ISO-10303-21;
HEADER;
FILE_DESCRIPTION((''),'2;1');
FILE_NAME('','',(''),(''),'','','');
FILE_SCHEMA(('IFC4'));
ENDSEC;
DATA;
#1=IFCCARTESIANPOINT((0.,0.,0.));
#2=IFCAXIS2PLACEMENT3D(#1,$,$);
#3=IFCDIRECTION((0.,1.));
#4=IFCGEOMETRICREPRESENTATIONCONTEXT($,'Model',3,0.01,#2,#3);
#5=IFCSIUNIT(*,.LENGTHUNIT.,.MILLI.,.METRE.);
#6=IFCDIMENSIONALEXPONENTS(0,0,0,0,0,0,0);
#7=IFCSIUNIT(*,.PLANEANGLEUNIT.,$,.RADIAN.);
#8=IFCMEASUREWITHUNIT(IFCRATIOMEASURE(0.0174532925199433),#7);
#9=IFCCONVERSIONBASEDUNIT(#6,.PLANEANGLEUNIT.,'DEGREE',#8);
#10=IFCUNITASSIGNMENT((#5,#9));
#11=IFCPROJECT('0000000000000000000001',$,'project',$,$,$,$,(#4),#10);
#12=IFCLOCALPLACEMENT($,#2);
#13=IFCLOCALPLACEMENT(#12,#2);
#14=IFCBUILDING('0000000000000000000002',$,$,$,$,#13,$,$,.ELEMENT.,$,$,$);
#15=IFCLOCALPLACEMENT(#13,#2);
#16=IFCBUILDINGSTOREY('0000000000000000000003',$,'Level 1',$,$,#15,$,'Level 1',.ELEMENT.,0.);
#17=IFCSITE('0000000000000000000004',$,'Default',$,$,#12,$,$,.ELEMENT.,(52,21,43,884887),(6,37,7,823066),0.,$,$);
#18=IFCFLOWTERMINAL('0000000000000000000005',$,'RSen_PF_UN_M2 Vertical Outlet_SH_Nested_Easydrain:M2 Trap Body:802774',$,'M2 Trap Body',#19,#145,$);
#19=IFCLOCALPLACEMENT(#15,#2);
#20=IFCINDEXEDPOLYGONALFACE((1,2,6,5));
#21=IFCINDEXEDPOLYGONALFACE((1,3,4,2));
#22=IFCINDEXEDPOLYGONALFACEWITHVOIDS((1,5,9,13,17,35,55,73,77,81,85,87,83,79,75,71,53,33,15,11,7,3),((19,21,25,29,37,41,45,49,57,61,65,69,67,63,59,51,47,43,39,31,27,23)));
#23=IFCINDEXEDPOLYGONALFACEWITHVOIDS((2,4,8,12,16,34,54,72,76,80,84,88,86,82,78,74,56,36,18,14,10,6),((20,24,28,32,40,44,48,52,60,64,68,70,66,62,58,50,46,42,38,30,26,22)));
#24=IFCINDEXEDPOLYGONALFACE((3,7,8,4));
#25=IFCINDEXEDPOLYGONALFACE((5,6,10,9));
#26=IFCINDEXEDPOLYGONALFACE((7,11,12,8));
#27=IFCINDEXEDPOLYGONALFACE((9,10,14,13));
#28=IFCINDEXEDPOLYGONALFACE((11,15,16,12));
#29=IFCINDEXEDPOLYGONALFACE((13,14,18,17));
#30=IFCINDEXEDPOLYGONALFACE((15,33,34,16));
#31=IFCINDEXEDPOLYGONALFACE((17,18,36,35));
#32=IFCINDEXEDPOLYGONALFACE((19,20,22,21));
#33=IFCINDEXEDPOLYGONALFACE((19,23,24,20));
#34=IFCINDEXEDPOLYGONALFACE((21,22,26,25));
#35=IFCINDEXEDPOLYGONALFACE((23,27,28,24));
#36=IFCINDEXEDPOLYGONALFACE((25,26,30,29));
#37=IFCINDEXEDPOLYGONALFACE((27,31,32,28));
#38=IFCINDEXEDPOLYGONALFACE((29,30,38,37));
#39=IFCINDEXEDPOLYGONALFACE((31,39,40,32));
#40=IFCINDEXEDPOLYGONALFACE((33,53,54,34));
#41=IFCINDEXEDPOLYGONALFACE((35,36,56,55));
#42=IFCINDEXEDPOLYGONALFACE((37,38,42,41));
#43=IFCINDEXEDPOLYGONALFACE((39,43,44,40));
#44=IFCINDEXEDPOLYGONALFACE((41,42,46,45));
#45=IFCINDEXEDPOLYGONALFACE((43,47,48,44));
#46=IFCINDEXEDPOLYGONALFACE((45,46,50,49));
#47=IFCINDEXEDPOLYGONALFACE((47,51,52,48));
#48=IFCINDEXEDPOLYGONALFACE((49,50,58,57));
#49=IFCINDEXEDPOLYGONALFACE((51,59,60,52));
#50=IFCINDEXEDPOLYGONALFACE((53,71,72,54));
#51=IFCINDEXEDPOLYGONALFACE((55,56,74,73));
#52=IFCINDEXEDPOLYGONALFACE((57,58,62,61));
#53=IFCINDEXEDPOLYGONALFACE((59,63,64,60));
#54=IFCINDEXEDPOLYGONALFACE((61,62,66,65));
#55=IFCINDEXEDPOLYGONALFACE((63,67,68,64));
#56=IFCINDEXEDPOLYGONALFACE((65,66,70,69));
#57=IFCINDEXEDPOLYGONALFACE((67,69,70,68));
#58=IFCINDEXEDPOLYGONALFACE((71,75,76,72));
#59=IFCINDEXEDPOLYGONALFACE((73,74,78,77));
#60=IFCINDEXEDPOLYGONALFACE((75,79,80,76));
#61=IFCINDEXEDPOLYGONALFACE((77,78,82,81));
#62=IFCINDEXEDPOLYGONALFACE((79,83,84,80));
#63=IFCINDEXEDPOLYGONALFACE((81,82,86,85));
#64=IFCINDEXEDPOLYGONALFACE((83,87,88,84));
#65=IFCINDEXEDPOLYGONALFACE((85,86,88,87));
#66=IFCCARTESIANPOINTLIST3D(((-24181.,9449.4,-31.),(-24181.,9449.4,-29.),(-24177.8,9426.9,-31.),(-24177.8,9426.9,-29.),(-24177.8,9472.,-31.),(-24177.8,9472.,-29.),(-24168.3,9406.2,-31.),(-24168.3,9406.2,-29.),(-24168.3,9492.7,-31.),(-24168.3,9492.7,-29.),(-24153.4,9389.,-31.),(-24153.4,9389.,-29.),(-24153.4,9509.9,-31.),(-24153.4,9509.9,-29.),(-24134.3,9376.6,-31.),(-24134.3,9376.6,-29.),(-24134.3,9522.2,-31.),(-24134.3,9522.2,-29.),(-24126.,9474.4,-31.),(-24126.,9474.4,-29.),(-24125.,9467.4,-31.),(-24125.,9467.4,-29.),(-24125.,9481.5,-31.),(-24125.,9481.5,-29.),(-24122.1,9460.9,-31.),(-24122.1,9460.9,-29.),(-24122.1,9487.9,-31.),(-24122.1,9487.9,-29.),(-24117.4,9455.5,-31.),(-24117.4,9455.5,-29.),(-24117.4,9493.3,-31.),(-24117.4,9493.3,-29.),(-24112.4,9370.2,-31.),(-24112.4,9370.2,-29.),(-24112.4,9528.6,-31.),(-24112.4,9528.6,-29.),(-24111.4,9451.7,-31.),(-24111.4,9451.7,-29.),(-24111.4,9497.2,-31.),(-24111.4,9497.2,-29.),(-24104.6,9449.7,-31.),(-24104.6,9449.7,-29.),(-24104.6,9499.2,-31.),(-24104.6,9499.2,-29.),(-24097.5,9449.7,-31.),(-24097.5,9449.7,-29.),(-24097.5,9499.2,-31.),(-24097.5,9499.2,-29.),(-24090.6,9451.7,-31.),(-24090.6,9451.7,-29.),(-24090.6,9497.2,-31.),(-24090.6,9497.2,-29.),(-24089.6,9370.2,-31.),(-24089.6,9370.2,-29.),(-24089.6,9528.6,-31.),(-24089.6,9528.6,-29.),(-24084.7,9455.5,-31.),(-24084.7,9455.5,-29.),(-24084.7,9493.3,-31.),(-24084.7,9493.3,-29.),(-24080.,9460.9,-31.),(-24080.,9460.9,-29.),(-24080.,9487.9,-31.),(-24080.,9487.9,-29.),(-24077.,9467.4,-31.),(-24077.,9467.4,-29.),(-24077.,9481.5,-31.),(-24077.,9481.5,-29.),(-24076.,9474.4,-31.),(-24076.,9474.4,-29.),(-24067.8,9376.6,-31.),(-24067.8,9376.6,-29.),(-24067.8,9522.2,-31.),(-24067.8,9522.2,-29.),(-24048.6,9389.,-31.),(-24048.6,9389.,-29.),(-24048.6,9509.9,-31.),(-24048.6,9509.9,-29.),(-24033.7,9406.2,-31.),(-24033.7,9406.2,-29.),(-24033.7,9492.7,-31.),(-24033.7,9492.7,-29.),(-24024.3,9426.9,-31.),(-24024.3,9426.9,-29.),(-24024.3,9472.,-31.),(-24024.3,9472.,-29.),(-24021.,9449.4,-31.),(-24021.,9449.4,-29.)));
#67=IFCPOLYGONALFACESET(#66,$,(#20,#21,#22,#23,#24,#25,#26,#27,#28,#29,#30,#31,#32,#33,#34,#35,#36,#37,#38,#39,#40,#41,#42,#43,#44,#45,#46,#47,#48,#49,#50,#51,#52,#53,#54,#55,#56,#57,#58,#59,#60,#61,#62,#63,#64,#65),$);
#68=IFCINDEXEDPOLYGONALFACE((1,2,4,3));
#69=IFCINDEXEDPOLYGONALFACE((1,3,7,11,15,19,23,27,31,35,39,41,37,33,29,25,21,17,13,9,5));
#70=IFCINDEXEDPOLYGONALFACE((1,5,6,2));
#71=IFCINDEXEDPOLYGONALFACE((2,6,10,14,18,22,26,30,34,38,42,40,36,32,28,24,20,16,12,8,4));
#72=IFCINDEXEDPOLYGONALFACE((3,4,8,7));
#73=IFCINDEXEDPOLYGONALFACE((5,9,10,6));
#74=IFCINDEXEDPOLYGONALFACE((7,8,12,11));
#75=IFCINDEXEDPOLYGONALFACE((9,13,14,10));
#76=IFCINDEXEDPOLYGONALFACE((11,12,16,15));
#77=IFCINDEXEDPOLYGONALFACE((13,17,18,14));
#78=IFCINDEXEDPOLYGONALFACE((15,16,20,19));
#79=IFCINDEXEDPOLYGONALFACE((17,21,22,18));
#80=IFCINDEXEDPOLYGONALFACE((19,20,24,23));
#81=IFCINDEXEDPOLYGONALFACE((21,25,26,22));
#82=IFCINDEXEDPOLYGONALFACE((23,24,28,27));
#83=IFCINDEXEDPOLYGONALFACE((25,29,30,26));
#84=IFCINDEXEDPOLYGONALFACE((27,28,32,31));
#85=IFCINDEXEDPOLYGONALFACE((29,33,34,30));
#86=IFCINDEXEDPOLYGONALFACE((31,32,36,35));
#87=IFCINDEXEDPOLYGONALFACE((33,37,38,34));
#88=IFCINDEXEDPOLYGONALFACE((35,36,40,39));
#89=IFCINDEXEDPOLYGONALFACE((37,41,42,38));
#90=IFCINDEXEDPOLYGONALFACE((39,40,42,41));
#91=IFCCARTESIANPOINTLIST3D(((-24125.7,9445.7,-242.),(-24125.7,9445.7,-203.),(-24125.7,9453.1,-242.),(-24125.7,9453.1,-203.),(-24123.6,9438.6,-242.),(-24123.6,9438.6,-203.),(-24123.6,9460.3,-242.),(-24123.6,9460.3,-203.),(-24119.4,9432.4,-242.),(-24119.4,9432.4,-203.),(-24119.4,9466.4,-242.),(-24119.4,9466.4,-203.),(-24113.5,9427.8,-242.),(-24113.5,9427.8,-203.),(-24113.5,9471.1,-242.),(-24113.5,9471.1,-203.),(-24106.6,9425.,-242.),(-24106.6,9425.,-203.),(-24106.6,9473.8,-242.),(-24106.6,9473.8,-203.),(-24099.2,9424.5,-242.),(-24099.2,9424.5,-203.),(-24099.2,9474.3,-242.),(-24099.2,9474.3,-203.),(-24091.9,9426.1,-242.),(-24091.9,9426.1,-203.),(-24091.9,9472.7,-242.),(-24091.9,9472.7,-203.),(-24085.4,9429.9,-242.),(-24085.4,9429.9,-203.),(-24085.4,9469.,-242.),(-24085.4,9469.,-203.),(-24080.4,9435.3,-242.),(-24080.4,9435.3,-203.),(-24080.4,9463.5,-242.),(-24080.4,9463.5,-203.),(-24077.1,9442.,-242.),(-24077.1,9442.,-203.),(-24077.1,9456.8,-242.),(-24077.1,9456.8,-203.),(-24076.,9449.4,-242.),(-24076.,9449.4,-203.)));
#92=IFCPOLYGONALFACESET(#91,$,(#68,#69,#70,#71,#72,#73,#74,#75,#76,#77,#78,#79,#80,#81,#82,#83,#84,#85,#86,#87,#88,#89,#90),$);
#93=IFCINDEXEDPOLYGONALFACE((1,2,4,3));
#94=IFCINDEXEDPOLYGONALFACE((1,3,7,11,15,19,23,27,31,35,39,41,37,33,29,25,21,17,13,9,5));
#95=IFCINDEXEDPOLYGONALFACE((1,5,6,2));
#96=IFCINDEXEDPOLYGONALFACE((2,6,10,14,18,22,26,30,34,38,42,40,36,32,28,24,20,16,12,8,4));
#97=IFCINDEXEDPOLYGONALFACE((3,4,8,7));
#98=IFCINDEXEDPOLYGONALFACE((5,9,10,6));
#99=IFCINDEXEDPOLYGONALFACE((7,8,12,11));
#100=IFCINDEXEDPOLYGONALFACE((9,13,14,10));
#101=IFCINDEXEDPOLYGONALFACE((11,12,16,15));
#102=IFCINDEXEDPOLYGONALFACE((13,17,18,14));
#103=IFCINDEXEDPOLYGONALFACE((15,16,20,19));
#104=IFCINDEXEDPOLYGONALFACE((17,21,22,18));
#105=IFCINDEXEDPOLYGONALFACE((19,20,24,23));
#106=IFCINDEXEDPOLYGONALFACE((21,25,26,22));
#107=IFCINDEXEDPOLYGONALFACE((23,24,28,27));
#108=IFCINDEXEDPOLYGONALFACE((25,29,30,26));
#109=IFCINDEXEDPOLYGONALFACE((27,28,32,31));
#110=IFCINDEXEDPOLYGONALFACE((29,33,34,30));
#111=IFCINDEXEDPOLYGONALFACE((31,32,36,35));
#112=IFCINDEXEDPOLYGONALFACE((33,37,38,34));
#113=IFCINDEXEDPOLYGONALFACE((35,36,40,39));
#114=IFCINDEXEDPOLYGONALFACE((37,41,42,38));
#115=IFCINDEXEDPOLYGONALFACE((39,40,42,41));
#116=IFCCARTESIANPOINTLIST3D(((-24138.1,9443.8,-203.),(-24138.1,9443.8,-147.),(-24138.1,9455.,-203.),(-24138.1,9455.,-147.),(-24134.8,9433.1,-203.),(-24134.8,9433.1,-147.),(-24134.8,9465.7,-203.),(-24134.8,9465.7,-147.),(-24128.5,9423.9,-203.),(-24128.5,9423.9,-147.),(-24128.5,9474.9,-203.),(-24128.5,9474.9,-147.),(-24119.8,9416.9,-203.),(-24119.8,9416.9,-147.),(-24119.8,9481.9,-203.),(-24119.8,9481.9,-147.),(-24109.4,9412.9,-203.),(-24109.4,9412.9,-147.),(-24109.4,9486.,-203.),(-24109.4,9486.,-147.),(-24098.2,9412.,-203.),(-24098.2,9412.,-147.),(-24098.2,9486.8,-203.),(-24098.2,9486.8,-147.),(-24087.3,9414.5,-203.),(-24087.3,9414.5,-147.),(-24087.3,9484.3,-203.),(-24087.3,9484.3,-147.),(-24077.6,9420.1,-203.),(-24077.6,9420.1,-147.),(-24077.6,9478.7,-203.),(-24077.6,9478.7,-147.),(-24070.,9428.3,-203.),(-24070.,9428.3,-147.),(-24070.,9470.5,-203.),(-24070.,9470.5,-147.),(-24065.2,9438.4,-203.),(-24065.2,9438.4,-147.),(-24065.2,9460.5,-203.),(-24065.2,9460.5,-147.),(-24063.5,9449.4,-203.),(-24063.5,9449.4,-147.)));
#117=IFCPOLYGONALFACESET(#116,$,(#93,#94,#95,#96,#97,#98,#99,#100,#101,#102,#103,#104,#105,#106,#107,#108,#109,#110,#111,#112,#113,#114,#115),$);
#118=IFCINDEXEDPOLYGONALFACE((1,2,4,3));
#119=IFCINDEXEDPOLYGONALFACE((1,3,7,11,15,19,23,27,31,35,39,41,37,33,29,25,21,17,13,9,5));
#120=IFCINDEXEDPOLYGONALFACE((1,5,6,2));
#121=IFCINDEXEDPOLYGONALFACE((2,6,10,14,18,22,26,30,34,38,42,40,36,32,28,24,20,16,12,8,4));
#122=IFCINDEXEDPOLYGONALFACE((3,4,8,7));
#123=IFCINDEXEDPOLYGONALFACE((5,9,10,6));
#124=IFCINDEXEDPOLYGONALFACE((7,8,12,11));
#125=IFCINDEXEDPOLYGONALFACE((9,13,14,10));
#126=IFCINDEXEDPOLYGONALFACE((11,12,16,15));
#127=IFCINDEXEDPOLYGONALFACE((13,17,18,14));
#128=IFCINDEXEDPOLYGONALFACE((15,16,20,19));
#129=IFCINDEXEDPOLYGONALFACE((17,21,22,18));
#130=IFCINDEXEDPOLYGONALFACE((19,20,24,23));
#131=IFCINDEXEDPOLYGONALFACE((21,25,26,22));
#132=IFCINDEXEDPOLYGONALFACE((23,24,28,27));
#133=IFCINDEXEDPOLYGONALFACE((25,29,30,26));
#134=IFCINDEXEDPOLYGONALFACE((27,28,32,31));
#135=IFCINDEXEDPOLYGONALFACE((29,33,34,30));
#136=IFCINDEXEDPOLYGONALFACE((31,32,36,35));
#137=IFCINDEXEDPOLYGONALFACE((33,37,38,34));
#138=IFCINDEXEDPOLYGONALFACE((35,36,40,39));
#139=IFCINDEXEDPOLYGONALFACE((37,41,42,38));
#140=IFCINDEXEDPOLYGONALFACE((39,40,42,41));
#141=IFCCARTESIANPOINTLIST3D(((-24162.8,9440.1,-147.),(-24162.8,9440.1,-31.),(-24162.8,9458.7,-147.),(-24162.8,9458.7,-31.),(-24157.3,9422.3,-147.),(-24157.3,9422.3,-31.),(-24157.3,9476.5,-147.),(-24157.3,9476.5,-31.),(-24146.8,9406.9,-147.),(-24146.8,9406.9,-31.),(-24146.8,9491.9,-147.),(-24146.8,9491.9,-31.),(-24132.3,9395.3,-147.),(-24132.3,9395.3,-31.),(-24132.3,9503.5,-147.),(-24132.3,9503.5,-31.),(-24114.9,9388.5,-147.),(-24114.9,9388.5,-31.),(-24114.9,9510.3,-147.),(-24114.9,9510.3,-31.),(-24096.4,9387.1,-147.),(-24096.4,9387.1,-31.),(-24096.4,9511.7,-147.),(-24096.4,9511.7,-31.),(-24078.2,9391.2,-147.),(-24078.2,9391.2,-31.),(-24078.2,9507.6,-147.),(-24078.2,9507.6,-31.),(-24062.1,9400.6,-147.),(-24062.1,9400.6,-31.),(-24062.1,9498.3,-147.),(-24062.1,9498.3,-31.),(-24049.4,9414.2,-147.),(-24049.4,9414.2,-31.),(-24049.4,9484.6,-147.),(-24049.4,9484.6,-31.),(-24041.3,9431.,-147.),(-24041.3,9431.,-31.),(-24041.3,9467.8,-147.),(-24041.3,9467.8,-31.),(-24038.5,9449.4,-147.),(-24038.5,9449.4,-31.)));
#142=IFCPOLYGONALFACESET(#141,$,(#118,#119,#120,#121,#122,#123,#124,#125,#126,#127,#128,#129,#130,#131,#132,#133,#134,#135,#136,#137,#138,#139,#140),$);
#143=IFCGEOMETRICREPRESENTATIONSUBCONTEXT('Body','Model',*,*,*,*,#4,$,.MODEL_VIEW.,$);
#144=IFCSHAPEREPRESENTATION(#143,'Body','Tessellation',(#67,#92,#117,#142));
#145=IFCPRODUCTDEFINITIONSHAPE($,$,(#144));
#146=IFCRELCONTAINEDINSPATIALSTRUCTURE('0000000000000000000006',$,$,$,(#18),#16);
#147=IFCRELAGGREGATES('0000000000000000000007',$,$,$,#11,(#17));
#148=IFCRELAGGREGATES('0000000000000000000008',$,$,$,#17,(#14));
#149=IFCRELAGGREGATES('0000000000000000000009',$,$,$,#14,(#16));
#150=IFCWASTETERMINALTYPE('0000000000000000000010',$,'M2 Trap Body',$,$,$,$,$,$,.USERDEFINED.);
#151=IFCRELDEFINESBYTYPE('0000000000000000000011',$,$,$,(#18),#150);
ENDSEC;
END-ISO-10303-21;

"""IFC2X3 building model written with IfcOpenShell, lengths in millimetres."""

from ifc_helpers import new_model, entity, si_unit, converted_unit, direction, frame, frame_2d, origin, origin_2d_with_axis, place, context, subcontext, project, spatial, circle_curve, parameter, trimmed, segment, composite_curve, circle, outline, extrude, source, transform, mapped, type_object, type_shapes, element, save


model = new_model("IFC2X3")

# Units and contexts
model_context = context("Model", 3, precision=0.01, world=origin(), true_north=direction((0.0, 1.0)))
body_context = subcontext(model_context, "Body", "Model", "MODEL_VIEW")
ifc_project = project(units=[si_unit("LENGTHUNIT", "METRE", prefix="MILLI"), converted_unit("PLANEANGLEUNIT", "DEGREE", entity("IfcRatioMeasure", 0.0174532925199433), si_unit("PLANEANGLEUNIT", "RADIAN"), dimensions=[0, 0, 0, 0, 0, 0, 0])], contexts=[model_context])

# Site, building, storey
site_placement = place(None, origin())
site = spatial("IfcSite", under=ifc_project, at=site_placement, Name="Default", CompositionType="ELEMENT", RefLatitude=(52, 21, 43, 884887), RefLongitude=(6, 37, 7, 823066), RefElevation=0.0)
building_placement = place(site_placement, origin())
building = spatial("IfcBuilding", under=site, at=building_placement, CompositionType="ELEMENT")
storey_placement = place(building_placement, origin())
storey = spatial("IfcBuildingStorey", under=building, at=storey_placement, Name="Level 1", LongName="Level 1", CompositionType="ELEMENT", Elevation=0.0)

# Flow terminal
waste_terminal_type_1 = type_object("IfcWasteTerminalType", Name="M2 Trap Body", PredefinedType="USERDEFINED")
shared_shape_1 = source(origin(), body_context, "Body", "SweptSolid", [
    extrude(outline(composite_curve([segment(trimmed(circle_curve(origin_2d_with_axis(), 80.0), [parameter(0.0)], [parameter(180.0)], True, "PARAMETER"), True, "CONTINUOUS"), segment(trimmed(circle_curve(origin_2d_with_axis(), 80.0), [parameter(180.0)], [parameter(360.0)], True, "PARAMETER"), True, "CONTINUOUS")], self_intersect=False), holes=[composite_curve([segment(trimmed(circle_curve(frame_2d((0.0, 25.0), x_axis=(1.0, 0.0)), 25.0), [parameter(180.0)], [parameter(360.0)], True, "PARAMETER"), False, "CONTINUOUS"), segment(trimmed(circle_curve(frame_2d((0.0, 25.0), x_axis=(1.0, 0.0)), 25.0), [parameter(0.0)], [parameter(180.0)], True, "PARAMETER"), False, "CONTINUOUS")], self_intersect=False)]), frame((0.0, -25.0, -2.0)), (0.0, 0.0, 1.0), 2.0),
    extrude(circle(Radius=25.0, at=frame_2d((0.0, 0.0), x_axis=(1.0, 0.0))), frame((0.0, -25.0, -213.0)), (0.0, 0.0, 1.0), 39.0),
    extrude(circle(Radius=37.5, at=frame_2d((0.0, 0.0), x_axis=(1.0, 0.0))), frame((0.0, -25.0, -174.0)), (0.0, 0.0, 1.0), 56.0),
    extrude(circle(Radius=62.5, at=frame_2d((0.0, 0.0), x_axis=(1.0, 0.0))), frame((0.0, -25.0, -118.0)), (0.0, 0.0, 1.0), 116.0),
])
type_shapes(waste_terminal_type_1, [shared_shape_1])
for number, where, name in (
    (1, (-24101.0, 9474.4, -29.0), "RSen_PF_UN_M2 Vertical Outlet_SH_Nested_Easydrain:M2 Trap Body:802774"),
):
    element("IfcFlowTerminal", number, at=place(storey_placement, frame(where)), inside=storey, type_object=waste_terminal_type_1, Name=name, ObjectType="M2 Trap Body", context=body_context, shape_type="MappedRepresentation", body=[
        mapped(shared_shape_1, transform((0.0, 0.0, 0.0), scale=1.0)),
    ])

save(model, "model.ifc")
